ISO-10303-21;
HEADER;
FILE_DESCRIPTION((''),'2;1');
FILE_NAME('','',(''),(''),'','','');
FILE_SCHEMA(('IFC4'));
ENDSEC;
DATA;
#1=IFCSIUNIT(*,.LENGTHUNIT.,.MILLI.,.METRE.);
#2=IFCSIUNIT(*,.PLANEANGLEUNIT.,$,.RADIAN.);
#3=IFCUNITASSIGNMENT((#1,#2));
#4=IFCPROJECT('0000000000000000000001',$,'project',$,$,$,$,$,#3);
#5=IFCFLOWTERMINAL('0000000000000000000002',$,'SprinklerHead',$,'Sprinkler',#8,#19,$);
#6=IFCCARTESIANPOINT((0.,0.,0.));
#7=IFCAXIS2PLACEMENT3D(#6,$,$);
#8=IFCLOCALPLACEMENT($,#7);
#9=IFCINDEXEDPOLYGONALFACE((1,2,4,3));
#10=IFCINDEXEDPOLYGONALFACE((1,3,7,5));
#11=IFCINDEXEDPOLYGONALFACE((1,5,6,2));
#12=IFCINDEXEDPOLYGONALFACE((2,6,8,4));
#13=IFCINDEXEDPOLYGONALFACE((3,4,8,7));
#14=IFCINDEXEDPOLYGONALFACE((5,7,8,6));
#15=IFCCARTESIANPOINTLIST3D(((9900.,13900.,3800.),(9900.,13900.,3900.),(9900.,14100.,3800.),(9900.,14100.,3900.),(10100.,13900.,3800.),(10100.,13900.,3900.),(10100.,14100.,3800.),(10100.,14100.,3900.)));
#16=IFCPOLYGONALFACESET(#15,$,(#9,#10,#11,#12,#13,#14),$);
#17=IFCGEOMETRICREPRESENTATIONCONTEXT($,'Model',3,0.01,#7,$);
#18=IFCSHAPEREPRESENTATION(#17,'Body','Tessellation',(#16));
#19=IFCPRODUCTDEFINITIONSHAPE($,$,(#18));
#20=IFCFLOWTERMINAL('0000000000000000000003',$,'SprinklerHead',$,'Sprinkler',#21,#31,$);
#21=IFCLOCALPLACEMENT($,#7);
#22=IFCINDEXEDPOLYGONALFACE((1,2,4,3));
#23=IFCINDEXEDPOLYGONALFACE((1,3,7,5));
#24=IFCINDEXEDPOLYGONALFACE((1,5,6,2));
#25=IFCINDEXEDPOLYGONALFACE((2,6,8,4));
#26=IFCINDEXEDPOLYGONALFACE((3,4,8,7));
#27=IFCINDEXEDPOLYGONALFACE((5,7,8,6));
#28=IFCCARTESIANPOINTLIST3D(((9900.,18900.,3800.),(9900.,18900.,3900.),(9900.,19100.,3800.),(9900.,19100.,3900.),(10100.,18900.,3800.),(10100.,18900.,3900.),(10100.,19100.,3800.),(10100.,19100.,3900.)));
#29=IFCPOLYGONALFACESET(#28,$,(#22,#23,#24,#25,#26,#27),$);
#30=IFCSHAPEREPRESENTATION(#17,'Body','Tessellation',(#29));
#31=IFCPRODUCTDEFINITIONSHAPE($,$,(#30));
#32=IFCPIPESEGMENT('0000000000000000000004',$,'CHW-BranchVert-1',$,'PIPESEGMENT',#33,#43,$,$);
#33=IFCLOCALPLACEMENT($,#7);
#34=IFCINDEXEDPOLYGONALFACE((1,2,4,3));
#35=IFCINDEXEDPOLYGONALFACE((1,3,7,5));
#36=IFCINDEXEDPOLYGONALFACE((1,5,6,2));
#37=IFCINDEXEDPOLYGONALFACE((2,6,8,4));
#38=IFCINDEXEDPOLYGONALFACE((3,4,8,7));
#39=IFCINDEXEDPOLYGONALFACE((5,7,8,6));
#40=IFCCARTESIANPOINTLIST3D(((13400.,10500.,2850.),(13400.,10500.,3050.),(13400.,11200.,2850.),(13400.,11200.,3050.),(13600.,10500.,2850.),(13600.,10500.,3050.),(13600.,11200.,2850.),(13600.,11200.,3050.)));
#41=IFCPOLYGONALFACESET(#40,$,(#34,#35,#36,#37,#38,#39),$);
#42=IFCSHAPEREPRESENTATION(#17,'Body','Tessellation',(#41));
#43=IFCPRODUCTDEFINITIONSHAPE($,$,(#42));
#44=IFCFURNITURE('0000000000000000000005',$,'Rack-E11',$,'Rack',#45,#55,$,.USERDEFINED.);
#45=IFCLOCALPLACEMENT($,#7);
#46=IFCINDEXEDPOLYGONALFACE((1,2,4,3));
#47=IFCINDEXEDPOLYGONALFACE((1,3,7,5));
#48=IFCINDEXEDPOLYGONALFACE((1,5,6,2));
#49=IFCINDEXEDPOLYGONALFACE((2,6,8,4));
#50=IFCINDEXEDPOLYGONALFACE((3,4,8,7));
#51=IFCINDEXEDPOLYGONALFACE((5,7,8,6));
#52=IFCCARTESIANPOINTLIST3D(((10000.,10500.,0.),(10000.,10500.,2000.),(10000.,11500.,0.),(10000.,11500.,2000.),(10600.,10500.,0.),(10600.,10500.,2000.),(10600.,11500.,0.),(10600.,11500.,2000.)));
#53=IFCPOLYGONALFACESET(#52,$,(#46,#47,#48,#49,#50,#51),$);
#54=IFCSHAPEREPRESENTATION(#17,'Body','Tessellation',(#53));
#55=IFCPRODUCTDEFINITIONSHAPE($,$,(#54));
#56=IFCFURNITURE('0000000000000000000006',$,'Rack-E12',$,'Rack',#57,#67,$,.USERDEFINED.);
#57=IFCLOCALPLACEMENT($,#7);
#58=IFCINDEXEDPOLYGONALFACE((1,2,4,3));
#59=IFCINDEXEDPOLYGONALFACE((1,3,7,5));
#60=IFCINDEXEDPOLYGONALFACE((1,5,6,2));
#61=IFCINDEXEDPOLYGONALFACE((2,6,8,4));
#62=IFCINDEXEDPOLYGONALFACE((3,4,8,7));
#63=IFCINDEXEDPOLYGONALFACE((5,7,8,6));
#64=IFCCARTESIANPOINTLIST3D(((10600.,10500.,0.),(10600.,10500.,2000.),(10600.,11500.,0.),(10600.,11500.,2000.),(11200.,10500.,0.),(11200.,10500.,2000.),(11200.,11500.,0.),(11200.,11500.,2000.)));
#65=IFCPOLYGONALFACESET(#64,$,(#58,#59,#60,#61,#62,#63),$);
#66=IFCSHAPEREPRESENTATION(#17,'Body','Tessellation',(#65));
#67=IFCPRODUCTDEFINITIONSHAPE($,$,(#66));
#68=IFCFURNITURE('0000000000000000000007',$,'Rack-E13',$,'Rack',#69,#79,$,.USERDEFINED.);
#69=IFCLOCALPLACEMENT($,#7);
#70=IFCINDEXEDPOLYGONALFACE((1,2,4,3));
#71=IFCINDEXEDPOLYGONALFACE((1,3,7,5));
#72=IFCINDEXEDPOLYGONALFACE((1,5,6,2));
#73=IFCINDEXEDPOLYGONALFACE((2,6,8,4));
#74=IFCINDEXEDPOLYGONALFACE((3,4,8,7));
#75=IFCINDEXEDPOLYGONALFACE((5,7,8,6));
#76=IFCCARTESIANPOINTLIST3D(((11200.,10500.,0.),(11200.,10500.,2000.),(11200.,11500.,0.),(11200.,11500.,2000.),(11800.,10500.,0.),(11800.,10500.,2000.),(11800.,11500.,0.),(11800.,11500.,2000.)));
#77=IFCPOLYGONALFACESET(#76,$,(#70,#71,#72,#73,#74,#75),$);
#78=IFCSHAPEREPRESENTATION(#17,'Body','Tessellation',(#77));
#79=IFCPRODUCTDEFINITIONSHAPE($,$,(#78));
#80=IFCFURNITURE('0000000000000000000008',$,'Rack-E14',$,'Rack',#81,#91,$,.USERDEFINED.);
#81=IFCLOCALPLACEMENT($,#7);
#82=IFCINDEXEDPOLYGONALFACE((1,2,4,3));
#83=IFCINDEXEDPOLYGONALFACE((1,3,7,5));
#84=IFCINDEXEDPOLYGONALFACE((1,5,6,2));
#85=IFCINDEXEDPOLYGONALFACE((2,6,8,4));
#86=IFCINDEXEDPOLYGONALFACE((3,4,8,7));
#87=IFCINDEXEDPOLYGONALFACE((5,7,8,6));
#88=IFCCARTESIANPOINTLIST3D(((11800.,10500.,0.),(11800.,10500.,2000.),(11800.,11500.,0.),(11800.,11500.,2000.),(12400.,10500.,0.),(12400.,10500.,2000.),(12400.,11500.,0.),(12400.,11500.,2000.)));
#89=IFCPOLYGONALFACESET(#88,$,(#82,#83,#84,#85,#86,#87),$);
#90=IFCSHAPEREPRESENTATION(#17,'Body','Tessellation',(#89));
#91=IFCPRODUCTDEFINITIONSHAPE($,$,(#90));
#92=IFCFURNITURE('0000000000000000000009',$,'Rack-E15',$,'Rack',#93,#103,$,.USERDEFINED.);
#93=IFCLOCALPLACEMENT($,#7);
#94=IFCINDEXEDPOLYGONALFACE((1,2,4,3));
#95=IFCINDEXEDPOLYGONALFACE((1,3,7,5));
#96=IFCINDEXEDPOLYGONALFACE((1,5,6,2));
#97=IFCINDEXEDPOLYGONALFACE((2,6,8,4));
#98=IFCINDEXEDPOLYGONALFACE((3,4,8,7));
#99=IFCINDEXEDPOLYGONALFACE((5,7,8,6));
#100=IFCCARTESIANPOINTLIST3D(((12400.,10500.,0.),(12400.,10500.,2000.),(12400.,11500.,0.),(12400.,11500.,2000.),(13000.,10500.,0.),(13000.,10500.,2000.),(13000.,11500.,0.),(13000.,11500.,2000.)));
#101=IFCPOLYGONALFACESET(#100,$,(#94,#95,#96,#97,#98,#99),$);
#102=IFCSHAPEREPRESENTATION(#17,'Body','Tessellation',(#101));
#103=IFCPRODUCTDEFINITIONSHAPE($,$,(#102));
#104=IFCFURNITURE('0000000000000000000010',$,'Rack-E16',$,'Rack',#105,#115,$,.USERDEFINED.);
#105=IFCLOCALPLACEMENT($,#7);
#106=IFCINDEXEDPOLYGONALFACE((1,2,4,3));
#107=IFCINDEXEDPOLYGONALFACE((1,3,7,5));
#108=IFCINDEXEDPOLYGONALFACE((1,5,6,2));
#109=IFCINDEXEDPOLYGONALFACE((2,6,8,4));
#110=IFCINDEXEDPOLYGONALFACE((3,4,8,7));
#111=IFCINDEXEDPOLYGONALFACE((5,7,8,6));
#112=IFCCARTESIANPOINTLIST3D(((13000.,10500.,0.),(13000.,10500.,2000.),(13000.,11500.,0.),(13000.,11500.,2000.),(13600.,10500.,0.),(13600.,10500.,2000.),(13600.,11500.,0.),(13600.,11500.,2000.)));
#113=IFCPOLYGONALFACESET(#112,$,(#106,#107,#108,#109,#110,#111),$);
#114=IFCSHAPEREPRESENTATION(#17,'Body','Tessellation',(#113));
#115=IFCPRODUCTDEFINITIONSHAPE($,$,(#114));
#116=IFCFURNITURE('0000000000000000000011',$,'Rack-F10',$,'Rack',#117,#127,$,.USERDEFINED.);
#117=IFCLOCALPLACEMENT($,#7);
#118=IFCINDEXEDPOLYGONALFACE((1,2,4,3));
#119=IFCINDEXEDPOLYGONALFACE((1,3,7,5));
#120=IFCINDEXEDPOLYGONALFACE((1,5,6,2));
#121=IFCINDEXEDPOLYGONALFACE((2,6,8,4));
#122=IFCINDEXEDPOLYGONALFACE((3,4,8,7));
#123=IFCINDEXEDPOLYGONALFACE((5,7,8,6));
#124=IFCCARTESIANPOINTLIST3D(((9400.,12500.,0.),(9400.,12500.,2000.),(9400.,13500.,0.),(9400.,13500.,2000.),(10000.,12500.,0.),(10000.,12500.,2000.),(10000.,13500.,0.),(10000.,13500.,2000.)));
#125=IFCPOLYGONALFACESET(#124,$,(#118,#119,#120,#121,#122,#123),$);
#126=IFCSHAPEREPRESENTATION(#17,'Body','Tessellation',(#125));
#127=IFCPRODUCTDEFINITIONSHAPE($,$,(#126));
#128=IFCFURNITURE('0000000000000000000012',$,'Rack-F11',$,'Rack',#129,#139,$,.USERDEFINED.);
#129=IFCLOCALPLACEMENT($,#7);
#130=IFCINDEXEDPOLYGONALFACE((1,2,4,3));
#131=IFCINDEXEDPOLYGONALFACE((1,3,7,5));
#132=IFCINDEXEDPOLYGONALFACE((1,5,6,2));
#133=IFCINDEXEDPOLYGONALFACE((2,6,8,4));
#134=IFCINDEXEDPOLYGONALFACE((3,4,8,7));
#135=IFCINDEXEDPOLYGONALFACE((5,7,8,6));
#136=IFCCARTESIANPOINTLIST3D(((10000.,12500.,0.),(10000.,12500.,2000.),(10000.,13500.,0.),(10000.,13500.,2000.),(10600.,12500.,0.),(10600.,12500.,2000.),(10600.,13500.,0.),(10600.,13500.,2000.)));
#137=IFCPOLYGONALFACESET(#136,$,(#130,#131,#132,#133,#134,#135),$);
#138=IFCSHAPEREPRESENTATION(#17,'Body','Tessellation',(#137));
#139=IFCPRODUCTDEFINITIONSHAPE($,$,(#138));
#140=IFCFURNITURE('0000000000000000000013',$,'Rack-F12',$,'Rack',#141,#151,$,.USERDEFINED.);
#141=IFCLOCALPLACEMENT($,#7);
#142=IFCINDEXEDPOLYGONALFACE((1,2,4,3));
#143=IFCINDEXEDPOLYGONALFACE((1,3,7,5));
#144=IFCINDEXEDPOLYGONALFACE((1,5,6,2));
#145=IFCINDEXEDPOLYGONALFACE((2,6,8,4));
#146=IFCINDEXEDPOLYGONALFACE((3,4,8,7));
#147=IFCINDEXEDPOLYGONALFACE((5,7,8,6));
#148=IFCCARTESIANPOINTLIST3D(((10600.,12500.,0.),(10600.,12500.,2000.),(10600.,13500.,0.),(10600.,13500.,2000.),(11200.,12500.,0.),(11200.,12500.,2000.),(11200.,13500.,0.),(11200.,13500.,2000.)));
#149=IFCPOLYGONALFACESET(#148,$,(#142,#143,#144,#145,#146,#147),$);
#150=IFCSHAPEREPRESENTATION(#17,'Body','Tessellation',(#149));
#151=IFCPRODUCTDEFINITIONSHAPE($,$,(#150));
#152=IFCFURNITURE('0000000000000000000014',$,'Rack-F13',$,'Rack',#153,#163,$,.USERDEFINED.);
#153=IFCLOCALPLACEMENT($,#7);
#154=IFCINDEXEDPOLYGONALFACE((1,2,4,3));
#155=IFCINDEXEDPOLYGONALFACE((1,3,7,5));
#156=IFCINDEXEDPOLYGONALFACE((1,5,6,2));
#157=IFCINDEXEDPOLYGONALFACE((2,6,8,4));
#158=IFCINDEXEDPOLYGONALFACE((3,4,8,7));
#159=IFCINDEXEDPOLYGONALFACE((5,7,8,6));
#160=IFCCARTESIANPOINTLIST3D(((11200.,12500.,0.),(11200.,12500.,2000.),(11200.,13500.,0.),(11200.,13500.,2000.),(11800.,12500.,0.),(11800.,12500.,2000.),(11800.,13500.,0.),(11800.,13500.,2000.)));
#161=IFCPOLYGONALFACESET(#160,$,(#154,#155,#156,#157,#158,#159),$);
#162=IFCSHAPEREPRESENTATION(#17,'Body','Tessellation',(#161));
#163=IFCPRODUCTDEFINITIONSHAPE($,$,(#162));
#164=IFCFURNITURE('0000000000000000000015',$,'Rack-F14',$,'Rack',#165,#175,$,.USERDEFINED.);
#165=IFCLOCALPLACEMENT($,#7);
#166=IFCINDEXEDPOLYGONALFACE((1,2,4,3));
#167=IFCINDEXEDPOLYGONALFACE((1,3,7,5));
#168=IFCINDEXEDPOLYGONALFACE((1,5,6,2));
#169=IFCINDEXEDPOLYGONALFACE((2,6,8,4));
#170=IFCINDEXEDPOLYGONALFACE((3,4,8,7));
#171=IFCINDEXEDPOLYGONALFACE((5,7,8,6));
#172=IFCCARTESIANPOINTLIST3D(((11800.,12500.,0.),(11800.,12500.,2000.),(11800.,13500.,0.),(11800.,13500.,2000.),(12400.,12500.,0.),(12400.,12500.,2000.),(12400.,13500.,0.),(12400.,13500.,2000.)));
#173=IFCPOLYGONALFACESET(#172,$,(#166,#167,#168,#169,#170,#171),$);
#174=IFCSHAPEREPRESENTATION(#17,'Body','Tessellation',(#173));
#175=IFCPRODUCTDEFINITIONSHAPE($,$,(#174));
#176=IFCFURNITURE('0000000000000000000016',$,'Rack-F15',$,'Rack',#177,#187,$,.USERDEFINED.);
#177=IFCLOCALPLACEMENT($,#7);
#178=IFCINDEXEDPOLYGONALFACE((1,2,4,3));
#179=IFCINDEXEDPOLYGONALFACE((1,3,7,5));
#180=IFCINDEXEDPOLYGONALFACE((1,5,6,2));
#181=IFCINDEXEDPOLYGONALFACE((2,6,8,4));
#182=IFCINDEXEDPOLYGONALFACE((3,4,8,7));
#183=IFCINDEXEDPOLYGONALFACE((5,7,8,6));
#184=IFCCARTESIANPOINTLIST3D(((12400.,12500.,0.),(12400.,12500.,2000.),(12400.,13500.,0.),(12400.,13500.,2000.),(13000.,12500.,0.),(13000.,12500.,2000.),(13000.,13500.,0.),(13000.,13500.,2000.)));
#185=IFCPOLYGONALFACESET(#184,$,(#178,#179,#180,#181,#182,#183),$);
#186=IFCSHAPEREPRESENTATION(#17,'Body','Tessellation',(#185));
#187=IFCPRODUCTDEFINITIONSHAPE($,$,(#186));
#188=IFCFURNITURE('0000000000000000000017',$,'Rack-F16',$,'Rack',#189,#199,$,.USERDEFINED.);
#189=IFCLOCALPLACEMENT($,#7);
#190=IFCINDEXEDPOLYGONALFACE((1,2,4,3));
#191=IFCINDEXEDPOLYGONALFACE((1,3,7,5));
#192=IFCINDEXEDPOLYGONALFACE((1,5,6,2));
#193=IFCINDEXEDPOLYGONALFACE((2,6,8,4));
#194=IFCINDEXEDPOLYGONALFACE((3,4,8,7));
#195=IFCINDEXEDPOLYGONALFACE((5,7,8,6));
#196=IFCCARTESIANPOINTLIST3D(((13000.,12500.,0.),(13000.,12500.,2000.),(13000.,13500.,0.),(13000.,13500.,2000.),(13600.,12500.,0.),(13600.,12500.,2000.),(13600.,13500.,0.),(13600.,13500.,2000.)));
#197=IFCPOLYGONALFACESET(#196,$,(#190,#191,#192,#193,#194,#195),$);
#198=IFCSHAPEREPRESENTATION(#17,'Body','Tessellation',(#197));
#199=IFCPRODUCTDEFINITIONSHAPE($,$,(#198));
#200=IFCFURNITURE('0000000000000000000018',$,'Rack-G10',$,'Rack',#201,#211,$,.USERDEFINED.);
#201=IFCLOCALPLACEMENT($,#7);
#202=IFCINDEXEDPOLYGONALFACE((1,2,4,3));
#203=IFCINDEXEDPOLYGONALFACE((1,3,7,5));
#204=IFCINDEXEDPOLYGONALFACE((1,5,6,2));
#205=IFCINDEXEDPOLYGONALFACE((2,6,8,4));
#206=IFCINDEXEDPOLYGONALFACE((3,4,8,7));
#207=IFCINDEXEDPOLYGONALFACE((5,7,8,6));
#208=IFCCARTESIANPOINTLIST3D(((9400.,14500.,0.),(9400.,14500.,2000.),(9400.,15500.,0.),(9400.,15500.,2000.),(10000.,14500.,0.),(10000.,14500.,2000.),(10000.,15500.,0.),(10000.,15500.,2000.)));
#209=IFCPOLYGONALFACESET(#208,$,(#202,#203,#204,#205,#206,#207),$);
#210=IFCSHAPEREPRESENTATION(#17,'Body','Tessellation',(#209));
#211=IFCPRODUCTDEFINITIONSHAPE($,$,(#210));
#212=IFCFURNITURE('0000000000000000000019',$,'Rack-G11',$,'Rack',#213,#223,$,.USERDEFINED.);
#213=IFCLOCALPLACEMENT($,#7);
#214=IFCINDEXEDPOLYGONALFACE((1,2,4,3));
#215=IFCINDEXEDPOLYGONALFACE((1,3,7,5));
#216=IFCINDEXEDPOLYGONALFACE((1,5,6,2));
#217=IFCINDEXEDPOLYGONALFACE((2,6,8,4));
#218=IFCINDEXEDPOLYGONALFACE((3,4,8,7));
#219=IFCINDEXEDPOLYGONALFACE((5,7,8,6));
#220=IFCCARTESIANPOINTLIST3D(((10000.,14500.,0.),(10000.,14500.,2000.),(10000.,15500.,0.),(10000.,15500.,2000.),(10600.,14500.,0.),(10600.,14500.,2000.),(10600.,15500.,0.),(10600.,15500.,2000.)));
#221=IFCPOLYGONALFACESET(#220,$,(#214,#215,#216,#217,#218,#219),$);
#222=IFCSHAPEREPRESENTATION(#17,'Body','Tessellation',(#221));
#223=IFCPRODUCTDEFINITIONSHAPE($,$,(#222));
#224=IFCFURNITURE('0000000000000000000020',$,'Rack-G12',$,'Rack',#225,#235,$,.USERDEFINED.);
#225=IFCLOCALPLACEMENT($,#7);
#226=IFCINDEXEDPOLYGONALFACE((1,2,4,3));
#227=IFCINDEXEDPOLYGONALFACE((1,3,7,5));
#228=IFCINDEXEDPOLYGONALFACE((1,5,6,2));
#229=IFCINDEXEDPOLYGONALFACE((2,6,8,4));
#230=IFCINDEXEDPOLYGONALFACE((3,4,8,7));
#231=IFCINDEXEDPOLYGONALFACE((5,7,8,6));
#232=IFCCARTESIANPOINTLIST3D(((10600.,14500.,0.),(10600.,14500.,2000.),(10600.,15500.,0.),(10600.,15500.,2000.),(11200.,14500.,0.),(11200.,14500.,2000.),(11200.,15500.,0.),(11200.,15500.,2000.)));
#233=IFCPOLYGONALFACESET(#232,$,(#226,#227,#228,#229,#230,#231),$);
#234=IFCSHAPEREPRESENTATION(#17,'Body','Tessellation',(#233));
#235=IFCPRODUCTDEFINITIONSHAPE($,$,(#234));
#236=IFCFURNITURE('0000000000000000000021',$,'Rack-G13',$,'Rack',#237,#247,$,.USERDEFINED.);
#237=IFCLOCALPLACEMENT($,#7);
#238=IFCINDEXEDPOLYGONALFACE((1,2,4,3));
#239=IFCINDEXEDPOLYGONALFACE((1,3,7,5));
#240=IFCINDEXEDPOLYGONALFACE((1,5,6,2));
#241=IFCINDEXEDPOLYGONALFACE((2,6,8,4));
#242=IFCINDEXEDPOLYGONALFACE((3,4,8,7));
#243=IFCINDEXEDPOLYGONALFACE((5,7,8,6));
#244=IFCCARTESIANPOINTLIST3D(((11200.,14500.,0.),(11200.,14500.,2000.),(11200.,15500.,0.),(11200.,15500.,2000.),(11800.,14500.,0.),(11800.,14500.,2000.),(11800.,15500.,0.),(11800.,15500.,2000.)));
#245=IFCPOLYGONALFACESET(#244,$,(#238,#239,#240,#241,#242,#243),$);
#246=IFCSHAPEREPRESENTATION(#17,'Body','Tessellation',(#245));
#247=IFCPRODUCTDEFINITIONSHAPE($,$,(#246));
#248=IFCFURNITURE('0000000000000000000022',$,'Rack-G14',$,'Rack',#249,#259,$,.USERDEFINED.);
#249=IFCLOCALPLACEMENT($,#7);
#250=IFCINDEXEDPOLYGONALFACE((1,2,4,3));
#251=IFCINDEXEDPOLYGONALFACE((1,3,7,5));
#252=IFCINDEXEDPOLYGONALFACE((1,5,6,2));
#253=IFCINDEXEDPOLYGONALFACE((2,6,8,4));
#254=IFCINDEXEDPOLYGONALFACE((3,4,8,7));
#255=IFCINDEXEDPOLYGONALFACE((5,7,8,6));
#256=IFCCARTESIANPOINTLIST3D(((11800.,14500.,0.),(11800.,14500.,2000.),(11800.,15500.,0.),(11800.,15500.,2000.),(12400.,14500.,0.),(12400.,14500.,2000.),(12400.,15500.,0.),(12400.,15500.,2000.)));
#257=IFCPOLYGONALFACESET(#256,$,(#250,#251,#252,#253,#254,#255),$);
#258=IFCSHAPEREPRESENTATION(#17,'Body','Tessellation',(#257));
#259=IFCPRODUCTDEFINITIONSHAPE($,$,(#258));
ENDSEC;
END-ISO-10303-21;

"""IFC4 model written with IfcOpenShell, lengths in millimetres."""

from ifc_helpers import new_model, si_unit, frame, origin, place, context, project, polyline, outline, extrude, element, save


model = new_model("IFC4")

# Units and contexts
model_context = context("Model", 3, precision=0.01, world=origin())
ifc_project = project(units=[si_unit("LENGTHUNIT", "METRE", prefix="MILLI"), si_unit("PLANEANGLEUNIT", "RADIAN")])

# Flow terminals
for number, where, name in (
    (1, (10000.0, 14000.0, 3800.0), "SprinklerHead"),
    (2, (10000.0, 19000.0, 3800.0), "SprinklerHead"),
):
    element("IfcFlowTerminal", number, at=place(None, frame(where)), Name=name, ObjectType="Sprinkler", context=model_context, shape_type="SweptSolid", body=[
        extrude(outline(polyline([(-100.0, -100.0), (100.0, -100.0), (100.0, 100.0), (-100.0, 100.0), (-100.0, -100.0)])), origin(), (0.0, 0.0, 1.0), 100.0),
    ])

# Pipe segment
pipe_segment_placement = place(None, frame((13500.0, 10850.0, 2850.0)))
element("IfcPipeSegment", 3, at=pipe_segment_placement, Name="CHW-BranchVert-1", ObjectType="PIPESEGMENT", context=model_context, shape_type="SweptSolid", body=[
    extrude(outline(polyline([(-100.0, -350.0), (100.0, -350.0), (100.0, 350.0), (-100.0, 350.0), (-100.0, -350.0)])), origin(), (0.0, 0.0, 1.0), 200.0),
])

# Furniture
for number, where, name in (
    (4, (10300.0, 11000.0, 0.0), "Rack-E11"),
    (5, (10900.0, 11000.0, 0.0), "Rack-E12"),
    (6, (11500.0, 11000.0, 0.0), "Rack-E13"),
    (7, (12100.0, 11000.0, 0.0), "Rack-E14"),
    (8, (12700.0, 11000.0, 0.0), "Rack-E15"),
    (9, (13300.0, 11000.0, 0.0), "Rack-E16"),
    (10, (9700.0, 13000.0, 0.0), "Rack-F10"),
    (11, (10300.0, 13000.0, 0.0), "Rack-F11"),
    (12, (10900.0, 13000.0, 0.0), "Rack-F12"),
    (13, (11500.0, 13000.0, 0.0), "Rack-F13"),
    (14, (12100.0, 13000.0, 0.0), "Rack-F14"),
    (15, (12700.0, 13000.0, 0.0), "Rack-F15"),
    (16, (13300.0, 13000.0, 0.0), "Rack-F16"),
    (17, (9700.0, 15000.0, 0.0), "Rack-G10"),
    (18, (10300.0, 15000.0, 0.0), "Rack-G11"),
    (19, (10900.0, 15000.0, 0.0), "Rack-G12"),
    (20, (11500.0, 15000.0, 0.0), "Rack-G13"),
    (21, (12100.0, 15000.0, 0.0), "Rack-G14"),
):
    element("IfcFurniture", number, at=place(None, frame(where)), Name=name, ObjectType="Rack", PredefinedType="USERDEFINED", context=model_context, shape_type="SweptSolid", body=[
        extrude(outline(polyline([(-300.0, -500.0), (300.0, -500.0), (300.0, 500.0), (-300.0, 500.0), (-300.0, -500.0)])), origin(), (0.0, 0.0, 1.0), 2000.0),
    ])

save(model, "model.ifc")
